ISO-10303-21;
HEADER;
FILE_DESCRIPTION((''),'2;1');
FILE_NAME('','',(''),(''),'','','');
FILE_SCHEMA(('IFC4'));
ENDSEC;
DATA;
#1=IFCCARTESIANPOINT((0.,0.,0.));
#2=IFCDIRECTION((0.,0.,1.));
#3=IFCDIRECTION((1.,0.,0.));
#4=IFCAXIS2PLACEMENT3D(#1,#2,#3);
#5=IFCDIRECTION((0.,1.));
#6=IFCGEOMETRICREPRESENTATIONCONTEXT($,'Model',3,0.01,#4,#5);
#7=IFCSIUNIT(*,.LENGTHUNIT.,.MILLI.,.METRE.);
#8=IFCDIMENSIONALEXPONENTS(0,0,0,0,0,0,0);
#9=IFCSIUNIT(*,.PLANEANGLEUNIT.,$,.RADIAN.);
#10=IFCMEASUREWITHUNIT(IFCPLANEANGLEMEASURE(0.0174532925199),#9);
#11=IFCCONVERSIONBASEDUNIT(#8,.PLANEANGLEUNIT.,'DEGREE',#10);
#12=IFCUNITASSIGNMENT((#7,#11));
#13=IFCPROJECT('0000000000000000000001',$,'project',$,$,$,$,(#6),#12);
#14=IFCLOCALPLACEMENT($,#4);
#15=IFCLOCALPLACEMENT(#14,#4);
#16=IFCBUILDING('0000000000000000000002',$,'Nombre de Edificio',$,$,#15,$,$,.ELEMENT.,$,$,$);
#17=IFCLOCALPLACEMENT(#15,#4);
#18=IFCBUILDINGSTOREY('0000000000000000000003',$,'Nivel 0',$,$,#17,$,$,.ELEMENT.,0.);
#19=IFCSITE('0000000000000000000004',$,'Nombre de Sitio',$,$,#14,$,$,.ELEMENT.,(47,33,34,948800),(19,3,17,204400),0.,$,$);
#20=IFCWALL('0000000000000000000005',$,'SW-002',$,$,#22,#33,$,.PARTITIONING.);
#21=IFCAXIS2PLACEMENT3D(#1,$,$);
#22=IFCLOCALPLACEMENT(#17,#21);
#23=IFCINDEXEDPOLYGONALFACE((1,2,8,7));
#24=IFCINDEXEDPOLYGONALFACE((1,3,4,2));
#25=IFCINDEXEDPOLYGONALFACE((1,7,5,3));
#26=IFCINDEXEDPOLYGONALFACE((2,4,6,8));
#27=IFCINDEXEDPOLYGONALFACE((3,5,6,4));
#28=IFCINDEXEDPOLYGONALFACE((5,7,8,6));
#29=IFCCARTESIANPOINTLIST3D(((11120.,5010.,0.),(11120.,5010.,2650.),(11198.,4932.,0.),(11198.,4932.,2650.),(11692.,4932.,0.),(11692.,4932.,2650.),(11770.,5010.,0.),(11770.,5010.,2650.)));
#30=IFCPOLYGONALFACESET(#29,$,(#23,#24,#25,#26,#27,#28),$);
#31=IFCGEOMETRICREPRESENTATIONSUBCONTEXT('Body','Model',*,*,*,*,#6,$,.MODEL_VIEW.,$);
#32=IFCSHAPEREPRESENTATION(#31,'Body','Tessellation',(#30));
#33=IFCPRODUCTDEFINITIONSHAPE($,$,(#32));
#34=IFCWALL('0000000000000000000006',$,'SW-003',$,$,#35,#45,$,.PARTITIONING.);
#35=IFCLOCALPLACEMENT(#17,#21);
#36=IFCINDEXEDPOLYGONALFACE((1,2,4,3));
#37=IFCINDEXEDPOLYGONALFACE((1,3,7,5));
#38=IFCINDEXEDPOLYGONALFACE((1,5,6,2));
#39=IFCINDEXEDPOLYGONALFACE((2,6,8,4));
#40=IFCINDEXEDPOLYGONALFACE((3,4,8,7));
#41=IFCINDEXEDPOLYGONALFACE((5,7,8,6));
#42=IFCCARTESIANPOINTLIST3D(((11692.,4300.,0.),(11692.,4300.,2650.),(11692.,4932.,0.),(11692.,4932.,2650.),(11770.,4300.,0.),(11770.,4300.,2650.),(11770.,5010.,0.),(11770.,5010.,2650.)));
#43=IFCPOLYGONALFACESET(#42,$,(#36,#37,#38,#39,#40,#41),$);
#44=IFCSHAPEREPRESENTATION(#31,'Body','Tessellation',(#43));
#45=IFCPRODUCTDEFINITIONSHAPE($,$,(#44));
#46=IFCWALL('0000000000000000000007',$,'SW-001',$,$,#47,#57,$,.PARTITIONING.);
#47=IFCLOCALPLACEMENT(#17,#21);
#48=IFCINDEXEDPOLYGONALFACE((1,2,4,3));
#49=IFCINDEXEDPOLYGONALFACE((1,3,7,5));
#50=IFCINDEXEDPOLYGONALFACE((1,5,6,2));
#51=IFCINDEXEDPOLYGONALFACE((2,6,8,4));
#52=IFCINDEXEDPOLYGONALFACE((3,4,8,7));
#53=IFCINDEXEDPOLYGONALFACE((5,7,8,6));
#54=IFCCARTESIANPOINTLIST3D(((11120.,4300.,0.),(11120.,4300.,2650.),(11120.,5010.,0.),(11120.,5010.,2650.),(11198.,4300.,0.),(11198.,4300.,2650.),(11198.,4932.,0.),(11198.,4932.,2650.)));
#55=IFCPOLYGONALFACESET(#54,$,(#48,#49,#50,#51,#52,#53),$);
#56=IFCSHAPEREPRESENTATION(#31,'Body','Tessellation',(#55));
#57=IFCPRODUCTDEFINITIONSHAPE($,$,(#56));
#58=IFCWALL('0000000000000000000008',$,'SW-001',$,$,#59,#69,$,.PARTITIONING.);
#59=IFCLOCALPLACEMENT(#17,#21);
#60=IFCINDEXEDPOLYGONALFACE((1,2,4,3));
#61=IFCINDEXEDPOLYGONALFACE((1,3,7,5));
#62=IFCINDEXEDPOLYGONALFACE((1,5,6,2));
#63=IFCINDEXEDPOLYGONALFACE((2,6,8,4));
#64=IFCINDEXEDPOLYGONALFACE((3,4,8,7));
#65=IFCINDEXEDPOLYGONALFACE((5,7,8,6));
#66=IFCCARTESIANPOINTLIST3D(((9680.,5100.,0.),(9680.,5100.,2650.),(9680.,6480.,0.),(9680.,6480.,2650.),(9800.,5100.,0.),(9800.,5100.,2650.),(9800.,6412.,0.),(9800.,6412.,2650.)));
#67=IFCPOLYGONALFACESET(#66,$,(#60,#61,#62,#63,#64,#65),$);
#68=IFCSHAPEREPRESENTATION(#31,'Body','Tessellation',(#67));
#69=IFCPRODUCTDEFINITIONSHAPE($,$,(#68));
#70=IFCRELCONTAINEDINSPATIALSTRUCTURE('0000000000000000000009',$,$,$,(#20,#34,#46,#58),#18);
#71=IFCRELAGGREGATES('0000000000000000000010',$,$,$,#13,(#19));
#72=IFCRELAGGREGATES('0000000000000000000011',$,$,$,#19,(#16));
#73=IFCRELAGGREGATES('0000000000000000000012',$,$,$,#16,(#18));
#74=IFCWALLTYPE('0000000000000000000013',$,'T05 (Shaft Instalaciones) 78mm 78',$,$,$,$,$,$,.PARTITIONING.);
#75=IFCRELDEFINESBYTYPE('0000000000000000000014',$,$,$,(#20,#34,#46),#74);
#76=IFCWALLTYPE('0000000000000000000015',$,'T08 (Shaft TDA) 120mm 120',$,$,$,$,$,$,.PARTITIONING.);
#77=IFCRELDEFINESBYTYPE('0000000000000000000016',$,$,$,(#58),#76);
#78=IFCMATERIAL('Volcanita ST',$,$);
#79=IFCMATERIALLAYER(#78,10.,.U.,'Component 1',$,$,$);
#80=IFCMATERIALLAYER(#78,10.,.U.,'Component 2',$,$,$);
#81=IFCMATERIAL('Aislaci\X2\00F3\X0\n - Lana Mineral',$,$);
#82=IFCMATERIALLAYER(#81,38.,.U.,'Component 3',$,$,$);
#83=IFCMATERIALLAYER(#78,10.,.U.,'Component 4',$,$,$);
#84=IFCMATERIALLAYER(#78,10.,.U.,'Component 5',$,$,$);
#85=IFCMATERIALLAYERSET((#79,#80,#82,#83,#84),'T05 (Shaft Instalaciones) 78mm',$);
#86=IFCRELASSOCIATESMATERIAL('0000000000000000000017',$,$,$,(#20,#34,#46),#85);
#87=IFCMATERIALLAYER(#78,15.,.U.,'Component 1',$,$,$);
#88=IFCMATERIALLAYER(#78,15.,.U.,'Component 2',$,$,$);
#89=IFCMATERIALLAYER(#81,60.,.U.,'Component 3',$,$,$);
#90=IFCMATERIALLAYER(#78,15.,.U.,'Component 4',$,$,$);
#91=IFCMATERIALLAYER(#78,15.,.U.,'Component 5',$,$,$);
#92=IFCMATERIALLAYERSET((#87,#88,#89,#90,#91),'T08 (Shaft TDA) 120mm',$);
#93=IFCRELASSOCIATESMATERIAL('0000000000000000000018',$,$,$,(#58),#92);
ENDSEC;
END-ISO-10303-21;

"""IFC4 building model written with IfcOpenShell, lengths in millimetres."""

from ifc_helpers import new_model, entity, si_unit, converted_unit, direction, frame, origin_with_axes, place, context, subcontext, project, spatial, line, indexed_curve, outline, extrude, material, layer, layer_set, layer_usage, type_object, element, save


model = new_model("IFC4")

# Units and contexts
model_context = context("Model", 3, precision=0.01, world=origin_with_axes(), true_north=direction((0.0, 1.0)))
body_context = subcontext(model_context, "Body", "Model", "MODEL_VIEW")
ifc_project = project(units=[si_unit("LENGTHUNIT", "METRE", prefix="MILLI"), converted_unit("PLANEANGLEUNIT", "DEGREE", entity("IfcPlaneAngleMeasure", 0.0174532925199), si_unit("PLANEANGLEUNIT", "RADIAN"), dimensions=[0, 0, 0, 0, 0, 0, 0])], contexts=[model_context])

# Site, building, storey
site_placement = place(None, origin_with_axes())
site = spatial("IfcSite", under=ifc_project, at=site_placement, Name="Nombre de Sitio", CompositionType="ELEMENT", RefLatitude=(47, 33, 34, 948800), RefLongitude=(19, 3, 17, 204400), RefElevation=0.0)
building_placement = place(site_placement, origin_with_axes())
building = spatial("IfcBuilding", under=site, at=building_placement, Name="Nombre de Edificio", CompositionType="ELEMENT")
storey_placement = place(building_placement, origin_with_axes())
storey = spatial("IfcBuildingStorey", under=building, at=storey_placement, Name="Nivel 0", CompositionType="ELEMENT", Elevation=0.0)

# Shared definitions
ifc_material_1 = material(Name="Volcanita ST")
ifc_material_2 = material(Name="Aislación - Lana Mineral")

# Walls
ifc_layer_1 = layer(ifc_material_1, 10.0, ventilated="UNKNOWN", Name="Component 1")
ifc_layer_2 = layer(ifc_material_1, 10.0, ventilated="UNKNOWN", Name="Component 2")
ifc_layer_3 = layer(ifc_material_2, 38.0, ventilated="UNKNOWN", Name="Component 3")
ifc_layer_4 = layer(ifc_material_1, 10.0, ventilated="UNKNOWN", Name="Component 4")
ifc_layer_5 = layer(ifc_material_1, 10.0, ventilated="UNKNOWN", Name="Component 5")
ifc_layer_set_1 = layer_set([ifc_layer_1, ifc_layer_2, ifc_layer_3, ifc_layer_4, ifc_layer_5], Name="T05 (Shaft Instalaciones) 78mm")
ifc_layer_usage_1 = layer_usage(ifc_layer_set_1, "AXIS2", "POSITIVE", -39.0)
wall_type_1 = type_object("IfcWallType", Name="T05 (Shaft Instalaciones) 78mm 78", PredefinedType="PARTITIONING")
wall_1_placement = place(storey_placement, frame((11159.0, 4971.0, 0.0), z_axis=(0.0, 0.0, 1.0), x_axis=(1.0, 0.0, 0.0)))
element("IfcWall", 1, at=wall_1_placement, inside=storey, type_object=wall_type_1, material=ifc_layer_usage_1, Name="SW-002", PredefinedType="PARTITIONING", context=body_context, shape_type="SweptSolid", body=[
    extrude(outline(indexed_curve([(39.0, -39.0), (533.0, -39.0), (611.0, 39.0), (-39.0, 39.0)], segments=[line(1, 2, 3, 4, 1)])), origin_with_axes(), (0.0, 0.0, 1.0), 2650.0),
])
ifc_layer_usage_2 = layer_usage(ifc_layer_set_1, "AXIS2", "POSITIVE", -39.0)
wall_2_placement = place(storey_placement, frame((11731.0, 4971.0, 0.0), z_axis=(0.0, 0.0, 1.0), x_axis=(0.0, -1.0, 0.0)))
element("IfcWall", 2, at=wall_2_placement, inside=storey, type_object=wall_type_1, material=ifc_layer_usage_2, Name="SW-003", PredefinedType="PARTITIONING", context=body_context, shape_type="SweptSolid", body=[
    extrude(outline(indexed_curve([(39.0, -39.0), (671.0, -39.0), (671.0, 39.0), (-39.0, 39.0)], segments=[line(1, 2, 3, 4, 1)])), origin_with_axes(), (0.0, 0.0, 1.0), 2650.0),
])
ifc_layer_usage_3 = layer_usage(ifc_layer_set_1, "AXIS2", "POSITIVE", -39.0)
wall_3_placement = place(storey_placement, frame((11159.0, 4300.0, 0.0), z_axis=(0.0, 0.0, 1.0), x_axis=(0.0, 1.0, 0.0)))
element("IfcWall", 3, at=wall_3_placement, inside=storey, type_object=wall_type_1, material=ifc_layer_usage_3, Name="SW-001", PredefinedType="PARTITIONING", context=body_context, shape_type="SweptSolid", body=[
    extrude(outline(indexed_curve([(0.0, -39.0), (632.0, -39.0), (710.0, 39.0), (0.0, 39.0)], segments=[line(1, 2, 3, 4, 1)])), origin_with_axes(), (0.0, 0.0, 1.0), 2650.0),
])
ifc_layer_6 = layer(ifc_material_1, 15.0, ventilated="UNKNOWN", Name="Component 1")
ifc_layer_7 = layer(ifc_material_1, 15.0, ventilated="UNKNOWN", Name="Component 2")
ifc_layer_8 = layer(ifc_material_2, 60.0, ventilated="UNKNOWN", Name="Component 3")
ifc_layer_9 = layer(ifc_material_1, 15.0, ventilated="UNKNOWN", Name="Component 4")
ifc_layer_10 = layer(ifc_material_1, 15.0, ventilated="UNKNOWN", Name="Component 5")
ifc_layer_set_2 = layer_set([ifc_layer_6, ifc_layer_7, ifc_layer_8, ifc_layer_9, ifc_layer_10], Name="T08 (Shaft TDA) 120mm")
ifc_layer_usage_4 = layer_usage(ifc_layer_set_2, "AXIS2", "POSITIVE", -60.0)
wall_type_2 = type_object("IfcWallType", Name="T08 (Shaft TDA) 120mm 120", PredefinedType="PARTITIONING")
wall_4_placement = place(storey_placement, frame((9740.0, 6446.0, 0.0), z_axis=(0.0, 0.0, 1.0), x_axis=(0.0, -1.0, 0.0)))
element("IfcWall", 4, at=wall_4_placement, inside=storey, type_object=wall_type_2, material=ifc_layer_usage_4, Name="SW-001", PredefinedType="PARTITIONING", context=body_context, shape_type="SweptSolid", body=[
    extrude(outline(indexed_curve([(-34.0, -60.0), (1346.0, -60.0), (1346.0, 60.0), (34.0, 60.0)], segments=[line(1, 2, 3, 4, 1)])), origin_with_axes(), (0.0, 0.0, 1.0), 2650.0),
])

save(model, "model.ifc")
